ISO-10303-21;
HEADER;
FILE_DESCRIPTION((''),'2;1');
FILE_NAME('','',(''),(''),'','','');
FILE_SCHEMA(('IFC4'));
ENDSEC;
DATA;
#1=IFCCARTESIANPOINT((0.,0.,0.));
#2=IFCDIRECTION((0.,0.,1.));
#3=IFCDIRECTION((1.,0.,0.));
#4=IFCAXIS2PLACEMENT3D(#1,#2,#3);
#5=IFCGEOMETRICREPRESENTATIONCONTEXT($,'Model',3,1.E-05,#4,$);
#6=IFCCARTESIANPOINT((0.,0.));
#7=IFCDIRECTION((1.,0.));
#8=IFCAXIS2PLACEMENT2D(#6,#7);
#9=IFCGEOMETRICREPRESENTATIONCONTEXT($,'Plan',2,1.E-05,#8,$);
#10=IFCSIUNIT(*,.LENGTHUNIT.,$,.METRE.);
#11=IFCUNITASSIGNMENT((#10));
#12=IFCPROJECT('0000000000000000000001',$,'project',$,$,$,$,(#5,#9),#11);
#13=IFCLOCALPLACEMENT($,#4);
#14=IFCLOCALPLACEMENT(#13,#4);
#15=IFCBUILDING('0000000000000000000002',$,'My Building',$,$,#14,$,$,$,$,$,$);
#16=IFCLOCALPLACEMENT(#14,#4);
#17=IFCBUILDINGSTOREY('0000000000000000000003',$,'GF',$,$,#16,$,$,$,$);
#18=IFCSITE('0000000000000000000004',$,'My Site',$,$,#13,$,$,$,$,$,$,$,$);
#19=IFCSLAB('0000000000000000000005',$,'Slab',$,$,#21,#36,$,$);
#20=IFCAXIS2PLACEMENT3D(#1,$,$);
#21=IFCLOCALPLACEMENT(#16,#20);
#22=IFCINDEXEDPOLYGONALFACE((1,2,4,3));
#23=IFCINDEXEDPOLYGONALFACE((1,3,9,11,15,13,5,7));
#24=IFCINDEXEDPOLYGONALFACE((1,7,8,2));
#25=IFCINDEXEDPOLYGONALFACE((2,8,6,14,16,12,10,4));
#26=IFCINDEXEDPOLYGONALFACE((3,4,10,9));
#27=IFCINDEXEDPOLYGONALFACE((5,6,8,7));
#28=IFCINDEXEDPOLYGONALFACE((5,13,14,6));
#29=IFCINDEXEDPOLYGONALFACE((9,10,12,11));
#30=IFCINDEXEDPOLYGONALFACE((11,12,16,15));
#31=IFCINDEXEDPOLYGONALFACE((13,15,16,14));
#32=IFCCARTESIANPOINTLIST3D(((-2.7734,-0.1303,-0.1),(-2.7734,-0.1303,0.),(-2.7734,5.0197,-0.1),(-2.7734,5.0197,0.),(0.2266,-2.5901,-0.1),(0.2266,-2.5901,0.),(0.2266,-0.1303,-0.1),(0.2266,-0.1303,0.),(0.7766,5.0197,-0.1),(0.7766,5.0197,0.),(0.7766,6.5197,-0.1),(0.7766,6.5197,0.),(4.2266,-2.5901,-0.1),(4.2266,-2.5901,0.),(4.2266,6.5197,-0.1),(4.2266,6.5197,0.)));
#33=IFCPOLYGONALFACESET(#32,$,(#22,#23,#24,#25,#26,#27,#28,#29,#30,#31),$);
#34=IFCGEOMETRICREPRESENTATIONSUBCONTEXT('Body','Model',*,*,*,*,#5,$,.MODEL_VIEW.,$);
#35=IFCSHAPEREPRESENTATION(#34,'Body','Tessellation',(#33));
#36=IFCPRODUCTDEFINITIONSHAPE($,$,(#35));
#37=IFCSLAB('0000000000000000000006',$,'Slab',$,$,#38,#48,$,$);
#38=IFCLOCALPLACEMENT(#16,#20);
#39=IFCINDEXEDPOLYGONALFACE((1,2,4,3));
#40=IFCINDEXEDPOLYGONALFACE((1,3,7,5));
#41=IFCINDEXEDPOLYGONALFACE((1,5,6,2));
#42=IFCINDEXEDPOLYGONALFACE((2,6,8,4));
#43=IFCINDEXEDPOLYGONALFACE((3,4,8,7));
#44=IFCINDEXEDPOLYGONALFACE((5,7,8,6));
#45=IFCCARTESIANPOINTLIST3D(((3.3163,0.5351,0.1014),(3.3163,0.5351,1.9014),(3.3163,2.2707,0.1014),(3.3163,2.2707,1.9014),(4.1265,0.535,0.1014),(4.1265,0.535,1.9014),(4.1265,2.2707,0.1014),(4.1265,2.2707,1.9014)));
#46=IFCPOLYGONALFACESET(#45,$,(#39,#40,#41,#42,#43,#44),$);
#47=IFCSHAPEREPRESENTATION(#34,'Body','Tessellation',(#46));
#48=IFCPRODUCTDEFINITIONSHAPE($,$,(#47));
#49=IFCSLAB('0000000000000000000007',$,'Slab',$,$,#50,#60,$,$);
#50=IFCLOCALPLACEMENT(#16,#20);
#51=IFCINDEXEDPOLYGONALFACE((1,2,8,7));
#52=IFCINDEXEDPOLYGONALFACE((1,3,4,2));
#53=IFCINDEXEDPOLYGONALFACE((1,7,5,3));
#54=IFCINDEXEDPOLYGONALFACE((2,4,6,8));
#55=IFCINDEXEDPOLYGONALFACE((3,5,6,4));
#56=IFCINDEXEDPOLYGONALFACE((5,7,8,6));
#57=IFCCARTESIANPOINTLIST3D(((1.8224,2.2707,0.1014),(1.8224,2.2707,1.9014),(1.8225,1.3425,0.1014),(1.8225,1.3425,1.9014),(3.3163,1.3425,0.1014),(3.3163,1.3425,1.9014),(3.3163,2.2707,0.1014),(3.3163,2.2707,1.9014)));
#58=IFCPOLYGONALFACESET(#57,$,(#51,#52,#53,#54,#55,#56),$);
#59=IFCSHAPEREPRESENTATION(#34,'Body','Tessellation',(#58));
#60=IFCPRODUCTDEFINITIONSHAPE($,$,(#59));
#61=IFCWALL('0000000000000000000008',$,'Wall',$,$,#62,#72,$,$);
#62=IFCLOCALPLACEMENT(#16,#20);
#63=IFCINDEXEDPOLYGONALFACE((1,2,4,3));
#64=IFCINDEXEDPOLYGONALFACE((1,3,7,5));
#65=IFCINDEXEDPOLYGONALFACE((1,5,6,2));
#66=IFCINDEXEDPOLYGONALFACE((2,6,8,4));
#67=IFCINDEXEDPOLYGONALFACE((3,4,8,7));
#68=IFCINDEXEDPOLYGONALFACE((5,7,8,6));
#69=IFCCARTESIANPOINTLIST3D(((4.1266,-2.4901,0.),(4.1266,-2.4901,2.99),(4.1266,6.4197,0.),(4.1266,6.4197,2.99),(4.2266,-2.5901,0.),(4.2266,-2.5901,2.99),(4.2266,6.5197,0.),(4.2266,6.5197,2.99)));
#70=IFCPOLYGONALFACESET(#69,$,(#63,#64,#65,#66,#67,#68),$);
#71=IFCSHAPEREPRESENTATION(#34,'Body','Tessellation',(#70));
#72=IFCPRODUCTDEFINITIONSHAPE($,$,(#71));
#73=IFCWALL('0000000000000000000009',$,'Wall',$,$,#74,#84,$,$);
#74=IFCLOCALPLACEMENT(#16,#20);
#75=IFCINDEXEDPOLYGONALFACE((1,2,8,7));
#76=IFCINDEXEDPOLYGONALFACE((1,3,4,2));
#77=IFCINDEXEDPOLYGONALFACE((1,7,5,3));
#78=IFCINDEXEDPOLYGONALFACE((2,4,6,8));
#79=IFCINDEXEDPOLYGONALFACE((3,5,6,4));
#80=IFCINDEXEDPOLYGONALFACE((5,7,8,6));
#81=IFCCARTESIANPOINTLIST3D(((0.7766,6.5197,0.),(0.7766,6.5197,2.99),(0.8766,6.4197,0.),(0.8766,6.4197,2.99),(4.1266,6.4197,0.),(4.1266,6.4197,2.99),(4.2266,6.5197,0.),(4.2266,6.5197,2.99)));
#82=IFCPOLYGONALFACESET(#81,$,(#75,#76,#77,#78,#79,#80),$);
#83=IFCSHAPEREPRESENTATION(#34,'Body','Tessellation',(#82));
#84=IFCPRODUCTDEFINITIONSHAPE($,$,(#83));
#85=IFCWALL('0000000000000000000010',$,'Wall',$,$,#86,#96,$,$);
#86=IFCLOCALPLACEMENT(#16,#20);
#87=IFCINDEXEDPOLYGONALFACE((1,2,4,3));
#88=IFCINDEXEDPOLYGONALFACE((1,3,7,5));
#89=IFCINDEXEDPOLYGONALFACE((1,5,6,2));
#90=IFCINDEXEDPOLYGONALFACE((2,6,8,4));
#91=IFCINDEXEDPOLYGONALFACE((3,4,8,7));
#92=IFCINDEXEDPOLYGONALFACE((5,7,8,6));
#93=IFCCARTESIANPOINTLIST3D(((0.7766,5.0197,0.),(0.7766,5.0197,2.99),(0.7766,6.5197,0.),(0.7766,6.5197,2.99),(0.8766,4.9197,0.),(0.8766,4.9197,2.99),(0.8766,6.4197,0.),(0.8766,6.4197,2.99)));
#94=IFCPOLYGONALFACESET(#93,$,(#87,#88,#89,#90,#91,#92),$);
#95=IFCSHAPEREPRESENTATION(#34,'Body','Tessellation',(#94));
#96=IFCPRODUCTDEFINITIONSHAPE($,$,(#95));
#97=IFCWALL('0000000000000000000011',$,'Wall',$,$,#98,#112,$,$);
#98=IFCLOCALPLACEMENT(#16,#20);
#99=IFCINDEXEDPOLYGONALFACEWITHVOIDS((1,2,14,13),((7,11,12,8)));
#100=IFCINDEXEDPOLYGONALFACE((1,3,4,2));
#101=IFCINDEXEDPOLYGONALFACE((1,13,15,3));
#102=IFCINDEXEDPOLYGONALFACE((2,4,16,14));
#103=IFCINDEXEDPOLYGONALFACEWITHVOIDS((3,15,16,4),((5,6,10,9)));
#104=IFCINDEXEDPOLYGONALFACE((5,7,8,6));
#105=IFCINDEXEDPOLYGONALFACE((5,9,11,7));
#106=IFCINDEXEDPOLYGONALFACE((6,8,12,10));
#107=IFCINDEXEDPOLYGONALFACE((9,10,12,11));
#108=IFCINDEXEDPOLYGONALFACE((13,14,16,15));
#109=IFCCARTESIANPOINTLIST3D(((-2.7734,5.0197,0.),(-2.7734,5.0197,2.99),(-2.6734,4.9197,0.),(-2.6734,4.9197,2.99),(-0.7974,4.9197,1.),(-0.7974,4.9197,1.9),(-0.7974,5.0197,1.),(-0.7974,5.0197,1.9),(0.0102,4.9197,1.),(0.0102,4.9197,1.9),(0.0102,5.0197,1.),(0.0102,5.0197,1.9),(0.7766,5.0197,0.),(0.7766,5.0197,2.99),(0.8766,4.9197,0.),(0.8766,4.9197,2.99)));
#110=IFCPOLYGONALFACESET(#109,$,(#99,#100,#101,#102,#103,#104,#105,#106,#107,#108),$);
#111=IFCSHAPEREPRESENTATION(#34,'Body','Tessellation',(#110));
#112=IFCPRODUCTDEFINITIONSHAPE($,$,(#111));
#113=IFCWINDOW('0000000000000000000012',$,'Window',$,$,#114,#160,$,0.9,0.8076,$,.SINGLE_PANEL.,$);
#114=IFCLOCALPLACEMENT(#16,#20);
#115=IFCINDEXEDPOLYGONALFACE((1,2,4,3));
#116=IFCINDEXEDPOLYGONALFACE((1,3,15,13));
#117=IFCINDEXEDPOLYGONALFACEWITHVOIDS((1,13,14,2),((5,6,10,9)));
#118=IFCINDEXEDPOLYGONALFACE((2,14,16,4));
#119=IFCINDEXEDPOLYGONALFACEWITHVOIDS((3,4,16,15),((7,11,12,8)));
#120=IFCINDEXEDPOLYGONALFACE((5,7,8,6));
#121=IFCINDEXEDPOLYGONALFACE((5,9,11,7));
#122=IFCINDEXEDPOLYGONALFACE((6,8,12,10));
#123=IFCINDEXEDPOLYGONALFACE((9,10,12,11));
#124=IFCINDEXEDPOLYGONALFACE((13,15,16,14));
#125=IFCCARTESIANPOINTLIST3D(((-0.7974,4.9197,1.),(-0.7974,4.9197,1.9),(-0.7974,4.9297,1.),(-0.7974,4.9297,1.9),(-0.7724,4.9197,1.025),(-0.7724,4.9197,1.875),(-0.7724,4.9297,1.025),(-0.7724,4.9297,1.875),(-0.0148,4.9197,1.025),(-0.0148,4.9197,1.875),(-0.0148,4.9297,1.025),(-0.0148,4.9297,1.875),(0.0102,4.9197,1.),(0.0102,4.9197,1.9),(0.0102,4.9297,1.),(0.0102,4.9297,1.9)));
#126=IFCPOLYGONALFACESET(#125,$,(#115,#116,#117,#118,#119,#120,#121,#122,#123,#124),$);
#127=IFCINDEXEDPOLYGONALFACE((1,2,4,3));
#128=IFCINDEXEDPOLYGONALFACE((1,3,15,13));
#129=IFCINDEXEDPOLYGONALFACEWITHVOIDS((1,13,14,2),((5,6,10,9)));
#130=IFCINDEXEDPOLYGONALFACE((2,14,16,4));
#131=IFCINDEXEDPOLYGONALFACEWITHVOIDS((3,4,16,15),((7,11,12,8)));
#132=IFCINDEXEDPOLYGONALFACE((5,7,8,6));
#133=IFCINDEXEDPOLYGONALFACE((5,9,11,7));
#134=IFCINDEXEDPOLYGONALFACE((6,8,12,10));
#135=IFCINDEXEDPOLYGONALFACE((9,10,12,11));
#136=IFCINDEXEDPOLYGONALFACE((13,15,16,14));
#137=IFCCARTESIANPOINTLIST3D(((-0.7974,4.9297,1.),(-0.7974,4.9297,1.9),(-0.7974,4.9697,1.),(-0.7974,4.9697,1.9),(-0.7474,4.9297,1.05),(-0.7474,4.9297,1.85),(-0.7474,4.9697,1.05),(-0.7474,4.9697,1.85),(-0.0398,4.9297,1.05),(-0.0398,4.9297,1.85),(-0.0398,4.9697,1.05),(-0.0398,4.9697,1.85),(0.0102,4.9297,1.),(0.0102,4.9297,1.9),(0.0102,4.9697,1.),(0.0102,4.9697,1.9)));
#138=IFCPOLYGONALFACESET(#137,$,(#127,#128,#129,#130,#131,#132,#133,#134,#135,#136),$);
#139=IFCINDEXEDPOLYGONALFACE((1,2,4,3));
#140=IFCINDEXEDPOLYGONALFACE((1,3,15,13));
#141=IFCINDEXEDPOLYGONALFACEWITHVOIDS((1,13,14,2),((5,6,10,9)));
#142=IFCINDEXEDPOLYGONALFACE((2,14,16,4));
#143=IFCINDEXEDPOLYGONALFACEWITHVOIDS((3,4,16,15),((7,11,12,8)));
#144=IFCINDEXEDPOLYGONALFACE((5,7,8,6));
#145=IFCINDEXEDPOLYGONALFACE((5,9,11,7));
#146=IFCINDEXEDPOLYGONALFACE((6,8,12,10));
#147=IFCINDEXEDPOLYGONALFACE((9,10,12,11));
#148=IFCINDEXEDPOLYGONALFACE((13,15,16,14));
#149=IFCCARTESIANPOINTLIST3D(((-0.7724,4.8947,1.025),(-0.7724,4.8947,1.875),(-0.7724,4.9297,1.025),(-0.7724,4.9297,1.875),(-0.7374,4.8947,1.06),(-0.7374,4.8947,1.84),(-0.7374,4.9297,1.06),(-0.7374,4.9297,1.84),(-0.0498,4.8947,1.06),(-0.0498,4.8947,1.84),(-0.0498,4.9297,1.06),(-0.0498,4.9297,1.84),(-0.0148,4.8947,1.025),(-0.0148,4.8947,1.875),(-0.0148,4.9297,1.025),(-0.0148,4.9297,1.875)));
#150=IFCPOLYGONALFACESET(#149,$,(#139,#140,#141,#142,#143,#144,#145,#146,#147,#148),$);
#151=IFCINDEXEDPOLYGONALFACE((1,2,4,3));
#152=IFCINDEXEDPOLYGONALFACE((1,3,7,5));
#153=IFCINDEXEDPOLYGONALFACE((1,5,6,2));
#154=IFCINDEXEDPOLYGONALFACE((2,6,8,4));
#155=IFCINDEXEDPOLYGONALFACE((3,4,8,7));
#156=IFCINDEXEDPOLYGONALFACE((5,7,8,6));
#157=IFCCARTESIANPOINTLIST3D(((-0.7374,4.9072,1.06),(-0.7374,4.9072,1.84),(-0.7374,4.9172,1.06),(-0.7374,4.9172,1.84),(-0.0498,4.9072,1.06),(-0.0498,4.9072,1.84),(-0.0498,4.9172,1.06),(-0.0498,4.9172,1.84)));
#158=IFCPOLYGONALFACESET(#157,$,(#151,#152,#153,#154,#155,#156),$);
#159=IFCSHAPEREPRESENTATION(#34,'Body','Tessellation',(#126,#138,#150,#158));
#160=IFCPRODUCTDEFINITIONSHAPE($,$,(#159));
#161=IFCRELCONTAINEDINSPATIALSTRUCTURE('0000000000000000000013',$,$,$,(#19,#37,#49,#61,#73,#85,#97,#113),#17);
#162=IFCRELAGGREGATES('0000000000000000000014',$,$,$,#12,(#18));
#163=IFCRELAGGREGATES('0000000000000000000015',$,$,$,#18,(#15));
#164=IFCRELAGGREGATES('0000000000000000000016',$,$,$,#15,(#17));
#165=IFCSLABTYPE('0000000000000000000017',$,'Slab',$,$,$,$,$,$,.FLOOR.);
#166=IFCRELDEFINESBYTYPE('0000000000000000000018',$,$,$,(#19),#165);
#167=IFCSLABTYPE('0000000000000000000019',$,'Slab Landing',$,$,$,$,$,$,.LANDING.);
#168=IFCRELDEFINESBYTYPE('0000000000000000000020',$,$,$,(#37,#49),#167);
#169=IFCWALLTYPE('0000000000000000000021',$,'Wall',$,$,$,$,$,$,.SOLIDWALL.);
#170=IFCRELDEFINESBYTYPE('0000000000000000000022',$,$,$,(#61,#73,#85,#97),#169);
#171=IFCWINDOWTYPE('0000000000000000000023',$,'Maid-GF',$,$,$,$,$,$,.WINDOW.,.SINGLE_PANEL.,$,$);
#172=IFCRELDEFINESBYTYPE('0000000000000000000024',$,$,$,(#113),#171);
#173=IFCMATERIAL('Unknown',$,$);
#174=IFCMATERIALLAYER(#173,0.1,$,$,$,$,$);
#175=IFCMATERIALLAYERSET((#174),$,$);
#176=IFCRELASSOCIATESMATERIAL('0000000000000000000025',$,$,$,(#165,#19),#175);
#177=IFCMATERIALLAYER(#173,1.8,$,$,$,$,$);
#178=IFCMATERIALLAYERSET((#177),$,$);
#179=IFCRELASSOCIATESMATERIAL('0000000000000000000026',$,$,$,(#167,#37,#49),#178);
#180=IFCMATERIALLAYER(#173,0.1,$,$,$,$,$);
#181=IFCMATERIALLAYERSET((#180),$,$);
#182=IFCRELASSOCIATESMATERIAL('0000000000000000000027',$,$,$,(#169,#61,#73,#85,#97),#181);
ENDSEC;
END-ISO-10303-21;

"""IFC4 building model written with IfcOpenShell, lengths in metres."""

from ifc_helpers import new_model, entity, si_unit, frame, origin_with_axes, origin_2d_with_axis, place, context, subcontext, project, spatial, line, indexed_curve, outline, extrude, shape, source, transform, mapped, material, layer, layer_set, layer_usage, type_object, type_shapes, element, fill, save


model = new_model("IFC4")

# Units and contexts
model_context = context("Model", 3, precision=1e-05, world=origin_with_axes())
plan_context = context("Plan", 2, precision=1e-05, world=origin_2d_with_axis())
body_context_1 = subcontext(model_context, "Body", "Model", "MODEL_VIEW")
body_context_2 = subcontext(plan_context, "Body", "Plan", "PLAN_VIEW")
ifc_project = project(units=[si_unit("LENGTHUNIT", "METRE")], contexts=[model_context, plan_context])

# Site, building, storey
site_placement = place(None, origin_with_axes())
site = spatial("IfcSite", under=ifc_project, at=site_placement, Name="My Site")
building_placement = place(site_placement, origin_with_axes())
building = spatial("IfcBuilding", under=site, at=building_placement, Name="My Building")
storey_placement = place(building_placement, origin_with_axes())
storey = spatial("IfcBuildingStorey", under=building, at=storey_placement, Name="GF")

# Slabs
ifc_material_1 = material(Name="Unknown")
ifc_layer_1 = layer(ifc_material_1, 0.1)
ifc_layer_set_1 = layer_set([ifc_layer_1])
ifc_layer_usage_1 = layer_usage(ifc_layer_set_1, "AXIS3", "POSITIVE", -0.1)
slab_type_1 = type_object("IfcSlabType", Name="Slab", PredefinedType="FLOOR", material=ifc_layer_set_1)
slab_1_placement = place(storey_placement, frame((4.2266, -2.5901, 0.0), z_axis=(0.0, 0.0, 1.0), x_axis=(1.0, 0.0, 0.0)))
element("IfcSlab", 1, at=slab_1_placement, inside=storey, type_object=slab_type_1, material=ifc_layer_usage_1, Name="Slab", context=body_context_1, shape_type="SweptSolid", body=[
    extrude(outline(indexed_curve([(0.0, 0.0), (0.0, 9.1098), (-3.45, 9.1098), (-3.45, 7.6098), (-7.0, 7.6098), (-7.0, 2.4598), (-4.0, 2.4598), (-4.0, 0.0), (0.0, 0.0)])), frame((0.0, 0.0, -0.1), z_axis=(0.0, 0.0, 1.0), x_axis=(1.0, 0.0, 0.0)), (0.0, 0.0, 1.0), 0.1),
])
ifc_layer_2 = layer(ifc_material_1, 1.8)
ifc_layer_set_2 = layer_set([ifc_layer_2])
ifc_layer_usage_2 = layer_usage(ifc_layer_set_2, "AXIS3", "POSITIVE", -1.8)
slab_type_2 = type_object("IfcSlabType", Name="Slab Landing", PredefinedType="LANDING", material=ifc_layer_set_2)
slab_2_placement = place(storey_placement, frame((3.3163, 0.5351, 1.9014), z_axis=(0.0, 0.0, 1.0), x_axis=(1.0, 0.0, 0.0)))
element("IfcSlab", 2, at=slab_2_placement, inside=storey, type_object=slab_type_2, material=ifc_layer_usage_2, Name="Slab", context=body_context_1, shape_type="SweptSolid", body=[
    extrude(outline(indexed_curve([(0.0, 0.0), (0.0, 1.7356), (0.8103, 1.7356), (0.8103, -0.0001), (0.0, 0.0)])), frame((0.0, 0.0, -1.8), z_axis=(0.0, 0.0, 1.0), x_axis=(1.0, 0.0, 0.0)), (0.0, 0.0, 1.0), 1.8),
])
ifc_layer_usage_3 = layer_usage(ifc_layer_set_2, "AXIS3", "POSITIVE", -1.8)
slab_3_placement = place(storey_placement, frame((1.8225, 1.3425, 1.9014), z_axis=(0.0, 0.0, 1.0), x_axis=(1.0, 0.0, 0.0)))
element("IfcSlab", 3, at=slab_3_placement, inside=storey, type_object=slab_type_2, material=ifc_layer_usage_3, Name="Slab", context=body_context_1, shape_type="SweptSolid", body=[
    extrude(outline(indexed_curve([(0.0, 0.0), (1.4938, 0.0), (1.4938, 0.9282), (0.0, 0.9282), (0.0, 0.0)])), frame((0.0, 0.0, -1.8), z_axis=(0.0, 0.0, 1.0), x_axis=(1.0, 0.0, 0.0)), (0.0, 0.0, 1.0), 1.8),
])

# Shared definitions
ifc_layer_3 = layer(ifc_material_1, 0.1)
ifc_layer_set_3 = layer_set([ifc_layer_3])
wall_type = type_object("IfcWallType", Name="Wall", PredefinedType="SOLIDWALL", material=ifc_layer_set_3)

# Walls
ifc_layer_usage_4 = layer_usage(ifc_layer_set_3, "AXIS2", "POSITIVE", 0.0)
wall_1_placement = place(storey_placement, frame((4.2266, -2.5901, 0.0), z_axis=(0.0, 0.0, 1.0), x_axis=(0.0, 1.0, 0.0)))
element("IfcWall", 4, at=wall_1_placement, inside=storey, type_object=wall_type, material=ifc_layer_usage_4, Name="Wall", context=body_context_1, shape_type="SweptSolid", body=[
    extrude(outline(indexed_curve([(0.0, 0.0), (0.1, 0.1), (9.0098, 0.1), (9.1098, 0.0)], segments=[line(1, 2, 3, 4, 1)])), origin_with_axes(), (0.0, 0.0, 1.0), 2.99),
])
ifc_layer_usage_5 = layer_usage(ifc_layer_set_3, "AXIS2", "POSITIVE", 0.0)
wall_2_placement = place(storey_placement, frame((4.2266, 6.5197, 0.0), z_axis=(0.0, 0.0, 1.0), x_axis=(-1.0, 0.0, 0.0)))
element("IfcWall", 5, at=wall_2_placement, inside=storey, type_object=wall_type, material=ifc_layer_usage_5, Name="Wall", context=body_context_1, shape_type="SweptSolid", body=[
    extrude(outline(indexed_curve([(0.0, 0.0), (0.1, 0.1), (3.35, 0.1), (3.45, 0.0)], segments=[line(1, 2, 3, 4, 1)])), origin_with_axes(), (0.0, 0.0, 1.0), 2.99),
])
ifc_layer_usage_6 = layer_usage(ifc_layer_set_3, "AXIS2", "POSITIVE", 0.0)
wall_3_placement = place(storey_placement, frame((0.7766, 6.5197, 0.0), z_axis=(0.0, 0.0, 1.0), x_axis=(0.0, -1.0, 0.0)))
element("IfcWall", 6, at=wall_3_placement, inside=storey, type_object=wall_type, material=ifc_layer_usage_6, Name="Wall", context=body_context_1, shape_type="SweptSolid", body=[
    extrude(outline(indexed_curve([(0.0, 0.0), (0.1, 0.1), (1.6, 0.1), (1.5, 0.0)], segments=[line(1, 2, 3, 4, 1)])), origin_with_axes(), (0.0, 0.0, 1.0), 2.99),
])

# Wall, opening, window
ifc_layer_usage_7 = layer_usage(ifc_layer_set_3, "AXIS2", "POSITIVE", 0.0)
wall_4_placement = place(storey_placement, frame((0.7766, 5.0197, 0.0), z_axis=(0.0, 0.0, 1.0), x_axis=(-1.0, 0.0, 0.0)))
wall_4 = element("IfcWall", 7, at=wall_4_placement, inside=storey, type_object=wall_type, material=ifc_layer_usage_7, Name="Wall", context=body_context_1, shape_type="SweptSolid", body=[
    extrude(outline(indexed_curve([(0.0, 0.0), (-0.1, 0.1), (3.45, 0.1), (3.55, 0.0)], segments=[line(1, 2, 3, 4, 1)])), origin_with_axes(), (0.0, 0.0, 1.0), 2.99),
])
shared_shape_1 = source(origin_with_axes(), body_context_1, "Body", "SweptSolid", [
    extrude(outline(indexed_curve([(0.0, 0.0), (0.8076, 0.0), (0.8076, 0.9), (0.0, 0.9)], segments=[line(1, 2, 3, 4, 1)])), frame((0.0, -0.6, 0.0), z_axis=(0.0, -1.0, 0.0), x_axis=(1.0, 0.0, 0.0)), (0.0, 0.0, -1.0), 1.2),
])
opening_1_placement = place(wall_4_placement, frame((0.7664, 0.0, 1.0), z_axis=(0.0, 0.0, 1.0), x_axis=(1.0, 0.0, 0.0)))
opening_1 = element("IfcOpeningElement", 8, at=opening_1_placement, cuts=wall_4, PredefinedType="OPENING", context=body_context_1, shape_type="MappedRepresentation", body=[
    mapped(shared_shape_1, transform((0.0, 0.0, 0.0), x_axis=(1.0, 0.0, 0.0), y_axis=(0.0, 1.0, 0.0), z_axis=(0.0, 0.0, 1.0), scale=1.0)),
])
window_type_1 = type_object("IfcWindowType", Name="Maid-GF", PartitioningType="SINGLE_PANEL", PredefinedType="WINDOW")
shared_shape_2 = source(origin_with_axes(), body_context_1, "Body", "SweptSolid", [
    extrude(outline(indexed_curve([(0.0, 0.0), (0.8076, 0.0), (0.8076, 0.9), (0.0, 0.9)], segments=[line(1, 2, 3, 4, 1)]), holes=[indexed_curve([(0.025, 0.025), (0.7826, 0.025), (0.7826, 0.875), (0.025, 0.875)], segments=[line(1, 2, 3, 4, 1)])]), frame((0.0, 0.09, 0.0), z_axis=(0.0, -1.0, 0.0), x_axis=(1.0, 0.0, 0.0)), (0.0, 0.0, -1.0), 0.01),
    extrude(outline(indexed_curve([(0.0, 0.0), (0.8076, 0.0), (0.8076, 0.9), (0.0, 0.9)], segments=[line(1, 2, 3, 4, 1)]), holes=[indexed_curve([(0.05, 0.05), (0.7576, 0.05), (0.7576, 0.85), (0.05, 0.85)], segments=[line(1, 2, 3, 4, 1)])]), frame((0.0, 0.05, 0.0), z_axis=(0.0, -1.0, 0.0), x_axis=(1.0, 0.0, 0.0)), (0.0, 0.0, -1.0), 0.04),
    extrude(outline(indexed_curve([(0.0, 0.0), (0.7576, 0.0), (0.7576, 0.85), (0.0, 0.85)], segments=[line(1, 2, 3, 4, 1)]), holes=[indexed_curve([(0.035, 0.035), (0.7226, 0.035), (0.7226, 0.815), (0.035, 0.815)], segments=[line(1, 2, 3, 4, 1)])]), frame((0.025, 0.09, 0.025), z_axis=(0.0, -1.0, 0.0), x_axis=(1.0, 0.0, 0.0)), (0.0, 0.0, -1.0), 0.035),
    extrude(outline(indexed_curve([(0.035, 0.035), (0.7226, 0.035), (0.7226, 0.815), (0.035, 0.815)], segments=[line(1, 2, 3, 4, 1)])), frame((0.025, 0.1025, 0.025), z_axis=(0.0, -1.0, 0.0), x_axis=(1.0, 0.0, 0.0)), (0.0, 0.0, -1.0), 0.01),
])
shared_shape_3 = source(origin_with_axes(), body_context_2, "Body", "Curve2D", [
    entity("IfcIndexedPolyCurve", entity("IfcCartesianPointList2D", [[0.05, 0.05], [0.7576, 0.05]])),
    entity("IfcIndexedPolyCurve", entity("IfcCartesianPointList2D", [[0.0, 0.1], [0.025, 0.1], [0.025, 0.09], [0.05, 0.09], [0.05, 0.05], [0.0, 0.05]]), [entity("IfcLineIndex", [1, 2, 3, 4, 5, 6, 1])]),
    entity("IfcIndexedPolyCurve", entity("IfcCartesianPointList2D", [[0.8076, 0.1], [0.7826, 0.1], [0.7826, 0.09], [0.7576, 0.09], [0.7576, 0.05], [0.8076, 0.05]]), [entity("IfcLineIndex", [1, 2, 3, 4, 5, 6, 1])]),
    entity("IfcIndexedPolyCurve", entity("IfcCartesianPointList2D", [[0.025, 0.09], [0.06, 0.09], [0.06, 0.125], [0.025, 0.125]]), [entity("IfcLineIndex", [1, 2, 3, 4, 1])]),
    entity("IfcIndexedPolyCurve", entity("IfcCartesianPointList2D", [[0.7826, 0.09], [0.7476, 0.09], [0.7476, 0.125], [0.7826, 0.125]]), [entity("IfcLineIndex", [1, 2, 3, 4, 1])]),
    entity("IfcIndexedPolyCurve", entity("IfcCartesianPointList2D", [[0.06, 0.09], [0.7476, 0.09]])),
    entity("IfcIndexedPolyCurve", entity("IfcCartesianPointList2D", [[0.06, 0.125], [0.7476, 0.125]])),
    entity("IfcIndexedPolyCurve", entity("IfcCartesianPointList2D", [[0.06, 0.1075], [0.7476, 0.1075]])),
])
type_shapes(window_type_1, [shared_shape_2, shared_shape_3])
window_1_placement = place(opening_1_placement, origin_with_axes())
window_1 = element("IfcWindow", 9, at=window_1_placement, inside=storey, type_object=window_type_1, Name="Window", OverallHeight=0.9, OverallWidth=0.8076, PartitioningType="SINGLE_PANEL", shapes=[
    shape(body_context_1, "Body", "MappedRepresentation", [mapped(shared_shape_2, transform((0.0, 0.0, 0.0), x_axis=(1.0, 0.0, 0.0), y_axis=(0.0, 1.0, 0.0), z_axis=(0.0, 0.0, 1.0), scale=1.0))]),
    shape(body_context_2, "Body", "MappedRepresentation", [mapped(shared_shape_3, transform((0.0, 0.0, 0.0), x_axis=(1.0, 0.0, 0.0), y_axis=(0.0, 1.0, 0.0), z_axis=(0.0, 0.0, 1.0), scale=1.0))]),
])
fill(opening_1, window_1)

save(model, "model.ifc")
